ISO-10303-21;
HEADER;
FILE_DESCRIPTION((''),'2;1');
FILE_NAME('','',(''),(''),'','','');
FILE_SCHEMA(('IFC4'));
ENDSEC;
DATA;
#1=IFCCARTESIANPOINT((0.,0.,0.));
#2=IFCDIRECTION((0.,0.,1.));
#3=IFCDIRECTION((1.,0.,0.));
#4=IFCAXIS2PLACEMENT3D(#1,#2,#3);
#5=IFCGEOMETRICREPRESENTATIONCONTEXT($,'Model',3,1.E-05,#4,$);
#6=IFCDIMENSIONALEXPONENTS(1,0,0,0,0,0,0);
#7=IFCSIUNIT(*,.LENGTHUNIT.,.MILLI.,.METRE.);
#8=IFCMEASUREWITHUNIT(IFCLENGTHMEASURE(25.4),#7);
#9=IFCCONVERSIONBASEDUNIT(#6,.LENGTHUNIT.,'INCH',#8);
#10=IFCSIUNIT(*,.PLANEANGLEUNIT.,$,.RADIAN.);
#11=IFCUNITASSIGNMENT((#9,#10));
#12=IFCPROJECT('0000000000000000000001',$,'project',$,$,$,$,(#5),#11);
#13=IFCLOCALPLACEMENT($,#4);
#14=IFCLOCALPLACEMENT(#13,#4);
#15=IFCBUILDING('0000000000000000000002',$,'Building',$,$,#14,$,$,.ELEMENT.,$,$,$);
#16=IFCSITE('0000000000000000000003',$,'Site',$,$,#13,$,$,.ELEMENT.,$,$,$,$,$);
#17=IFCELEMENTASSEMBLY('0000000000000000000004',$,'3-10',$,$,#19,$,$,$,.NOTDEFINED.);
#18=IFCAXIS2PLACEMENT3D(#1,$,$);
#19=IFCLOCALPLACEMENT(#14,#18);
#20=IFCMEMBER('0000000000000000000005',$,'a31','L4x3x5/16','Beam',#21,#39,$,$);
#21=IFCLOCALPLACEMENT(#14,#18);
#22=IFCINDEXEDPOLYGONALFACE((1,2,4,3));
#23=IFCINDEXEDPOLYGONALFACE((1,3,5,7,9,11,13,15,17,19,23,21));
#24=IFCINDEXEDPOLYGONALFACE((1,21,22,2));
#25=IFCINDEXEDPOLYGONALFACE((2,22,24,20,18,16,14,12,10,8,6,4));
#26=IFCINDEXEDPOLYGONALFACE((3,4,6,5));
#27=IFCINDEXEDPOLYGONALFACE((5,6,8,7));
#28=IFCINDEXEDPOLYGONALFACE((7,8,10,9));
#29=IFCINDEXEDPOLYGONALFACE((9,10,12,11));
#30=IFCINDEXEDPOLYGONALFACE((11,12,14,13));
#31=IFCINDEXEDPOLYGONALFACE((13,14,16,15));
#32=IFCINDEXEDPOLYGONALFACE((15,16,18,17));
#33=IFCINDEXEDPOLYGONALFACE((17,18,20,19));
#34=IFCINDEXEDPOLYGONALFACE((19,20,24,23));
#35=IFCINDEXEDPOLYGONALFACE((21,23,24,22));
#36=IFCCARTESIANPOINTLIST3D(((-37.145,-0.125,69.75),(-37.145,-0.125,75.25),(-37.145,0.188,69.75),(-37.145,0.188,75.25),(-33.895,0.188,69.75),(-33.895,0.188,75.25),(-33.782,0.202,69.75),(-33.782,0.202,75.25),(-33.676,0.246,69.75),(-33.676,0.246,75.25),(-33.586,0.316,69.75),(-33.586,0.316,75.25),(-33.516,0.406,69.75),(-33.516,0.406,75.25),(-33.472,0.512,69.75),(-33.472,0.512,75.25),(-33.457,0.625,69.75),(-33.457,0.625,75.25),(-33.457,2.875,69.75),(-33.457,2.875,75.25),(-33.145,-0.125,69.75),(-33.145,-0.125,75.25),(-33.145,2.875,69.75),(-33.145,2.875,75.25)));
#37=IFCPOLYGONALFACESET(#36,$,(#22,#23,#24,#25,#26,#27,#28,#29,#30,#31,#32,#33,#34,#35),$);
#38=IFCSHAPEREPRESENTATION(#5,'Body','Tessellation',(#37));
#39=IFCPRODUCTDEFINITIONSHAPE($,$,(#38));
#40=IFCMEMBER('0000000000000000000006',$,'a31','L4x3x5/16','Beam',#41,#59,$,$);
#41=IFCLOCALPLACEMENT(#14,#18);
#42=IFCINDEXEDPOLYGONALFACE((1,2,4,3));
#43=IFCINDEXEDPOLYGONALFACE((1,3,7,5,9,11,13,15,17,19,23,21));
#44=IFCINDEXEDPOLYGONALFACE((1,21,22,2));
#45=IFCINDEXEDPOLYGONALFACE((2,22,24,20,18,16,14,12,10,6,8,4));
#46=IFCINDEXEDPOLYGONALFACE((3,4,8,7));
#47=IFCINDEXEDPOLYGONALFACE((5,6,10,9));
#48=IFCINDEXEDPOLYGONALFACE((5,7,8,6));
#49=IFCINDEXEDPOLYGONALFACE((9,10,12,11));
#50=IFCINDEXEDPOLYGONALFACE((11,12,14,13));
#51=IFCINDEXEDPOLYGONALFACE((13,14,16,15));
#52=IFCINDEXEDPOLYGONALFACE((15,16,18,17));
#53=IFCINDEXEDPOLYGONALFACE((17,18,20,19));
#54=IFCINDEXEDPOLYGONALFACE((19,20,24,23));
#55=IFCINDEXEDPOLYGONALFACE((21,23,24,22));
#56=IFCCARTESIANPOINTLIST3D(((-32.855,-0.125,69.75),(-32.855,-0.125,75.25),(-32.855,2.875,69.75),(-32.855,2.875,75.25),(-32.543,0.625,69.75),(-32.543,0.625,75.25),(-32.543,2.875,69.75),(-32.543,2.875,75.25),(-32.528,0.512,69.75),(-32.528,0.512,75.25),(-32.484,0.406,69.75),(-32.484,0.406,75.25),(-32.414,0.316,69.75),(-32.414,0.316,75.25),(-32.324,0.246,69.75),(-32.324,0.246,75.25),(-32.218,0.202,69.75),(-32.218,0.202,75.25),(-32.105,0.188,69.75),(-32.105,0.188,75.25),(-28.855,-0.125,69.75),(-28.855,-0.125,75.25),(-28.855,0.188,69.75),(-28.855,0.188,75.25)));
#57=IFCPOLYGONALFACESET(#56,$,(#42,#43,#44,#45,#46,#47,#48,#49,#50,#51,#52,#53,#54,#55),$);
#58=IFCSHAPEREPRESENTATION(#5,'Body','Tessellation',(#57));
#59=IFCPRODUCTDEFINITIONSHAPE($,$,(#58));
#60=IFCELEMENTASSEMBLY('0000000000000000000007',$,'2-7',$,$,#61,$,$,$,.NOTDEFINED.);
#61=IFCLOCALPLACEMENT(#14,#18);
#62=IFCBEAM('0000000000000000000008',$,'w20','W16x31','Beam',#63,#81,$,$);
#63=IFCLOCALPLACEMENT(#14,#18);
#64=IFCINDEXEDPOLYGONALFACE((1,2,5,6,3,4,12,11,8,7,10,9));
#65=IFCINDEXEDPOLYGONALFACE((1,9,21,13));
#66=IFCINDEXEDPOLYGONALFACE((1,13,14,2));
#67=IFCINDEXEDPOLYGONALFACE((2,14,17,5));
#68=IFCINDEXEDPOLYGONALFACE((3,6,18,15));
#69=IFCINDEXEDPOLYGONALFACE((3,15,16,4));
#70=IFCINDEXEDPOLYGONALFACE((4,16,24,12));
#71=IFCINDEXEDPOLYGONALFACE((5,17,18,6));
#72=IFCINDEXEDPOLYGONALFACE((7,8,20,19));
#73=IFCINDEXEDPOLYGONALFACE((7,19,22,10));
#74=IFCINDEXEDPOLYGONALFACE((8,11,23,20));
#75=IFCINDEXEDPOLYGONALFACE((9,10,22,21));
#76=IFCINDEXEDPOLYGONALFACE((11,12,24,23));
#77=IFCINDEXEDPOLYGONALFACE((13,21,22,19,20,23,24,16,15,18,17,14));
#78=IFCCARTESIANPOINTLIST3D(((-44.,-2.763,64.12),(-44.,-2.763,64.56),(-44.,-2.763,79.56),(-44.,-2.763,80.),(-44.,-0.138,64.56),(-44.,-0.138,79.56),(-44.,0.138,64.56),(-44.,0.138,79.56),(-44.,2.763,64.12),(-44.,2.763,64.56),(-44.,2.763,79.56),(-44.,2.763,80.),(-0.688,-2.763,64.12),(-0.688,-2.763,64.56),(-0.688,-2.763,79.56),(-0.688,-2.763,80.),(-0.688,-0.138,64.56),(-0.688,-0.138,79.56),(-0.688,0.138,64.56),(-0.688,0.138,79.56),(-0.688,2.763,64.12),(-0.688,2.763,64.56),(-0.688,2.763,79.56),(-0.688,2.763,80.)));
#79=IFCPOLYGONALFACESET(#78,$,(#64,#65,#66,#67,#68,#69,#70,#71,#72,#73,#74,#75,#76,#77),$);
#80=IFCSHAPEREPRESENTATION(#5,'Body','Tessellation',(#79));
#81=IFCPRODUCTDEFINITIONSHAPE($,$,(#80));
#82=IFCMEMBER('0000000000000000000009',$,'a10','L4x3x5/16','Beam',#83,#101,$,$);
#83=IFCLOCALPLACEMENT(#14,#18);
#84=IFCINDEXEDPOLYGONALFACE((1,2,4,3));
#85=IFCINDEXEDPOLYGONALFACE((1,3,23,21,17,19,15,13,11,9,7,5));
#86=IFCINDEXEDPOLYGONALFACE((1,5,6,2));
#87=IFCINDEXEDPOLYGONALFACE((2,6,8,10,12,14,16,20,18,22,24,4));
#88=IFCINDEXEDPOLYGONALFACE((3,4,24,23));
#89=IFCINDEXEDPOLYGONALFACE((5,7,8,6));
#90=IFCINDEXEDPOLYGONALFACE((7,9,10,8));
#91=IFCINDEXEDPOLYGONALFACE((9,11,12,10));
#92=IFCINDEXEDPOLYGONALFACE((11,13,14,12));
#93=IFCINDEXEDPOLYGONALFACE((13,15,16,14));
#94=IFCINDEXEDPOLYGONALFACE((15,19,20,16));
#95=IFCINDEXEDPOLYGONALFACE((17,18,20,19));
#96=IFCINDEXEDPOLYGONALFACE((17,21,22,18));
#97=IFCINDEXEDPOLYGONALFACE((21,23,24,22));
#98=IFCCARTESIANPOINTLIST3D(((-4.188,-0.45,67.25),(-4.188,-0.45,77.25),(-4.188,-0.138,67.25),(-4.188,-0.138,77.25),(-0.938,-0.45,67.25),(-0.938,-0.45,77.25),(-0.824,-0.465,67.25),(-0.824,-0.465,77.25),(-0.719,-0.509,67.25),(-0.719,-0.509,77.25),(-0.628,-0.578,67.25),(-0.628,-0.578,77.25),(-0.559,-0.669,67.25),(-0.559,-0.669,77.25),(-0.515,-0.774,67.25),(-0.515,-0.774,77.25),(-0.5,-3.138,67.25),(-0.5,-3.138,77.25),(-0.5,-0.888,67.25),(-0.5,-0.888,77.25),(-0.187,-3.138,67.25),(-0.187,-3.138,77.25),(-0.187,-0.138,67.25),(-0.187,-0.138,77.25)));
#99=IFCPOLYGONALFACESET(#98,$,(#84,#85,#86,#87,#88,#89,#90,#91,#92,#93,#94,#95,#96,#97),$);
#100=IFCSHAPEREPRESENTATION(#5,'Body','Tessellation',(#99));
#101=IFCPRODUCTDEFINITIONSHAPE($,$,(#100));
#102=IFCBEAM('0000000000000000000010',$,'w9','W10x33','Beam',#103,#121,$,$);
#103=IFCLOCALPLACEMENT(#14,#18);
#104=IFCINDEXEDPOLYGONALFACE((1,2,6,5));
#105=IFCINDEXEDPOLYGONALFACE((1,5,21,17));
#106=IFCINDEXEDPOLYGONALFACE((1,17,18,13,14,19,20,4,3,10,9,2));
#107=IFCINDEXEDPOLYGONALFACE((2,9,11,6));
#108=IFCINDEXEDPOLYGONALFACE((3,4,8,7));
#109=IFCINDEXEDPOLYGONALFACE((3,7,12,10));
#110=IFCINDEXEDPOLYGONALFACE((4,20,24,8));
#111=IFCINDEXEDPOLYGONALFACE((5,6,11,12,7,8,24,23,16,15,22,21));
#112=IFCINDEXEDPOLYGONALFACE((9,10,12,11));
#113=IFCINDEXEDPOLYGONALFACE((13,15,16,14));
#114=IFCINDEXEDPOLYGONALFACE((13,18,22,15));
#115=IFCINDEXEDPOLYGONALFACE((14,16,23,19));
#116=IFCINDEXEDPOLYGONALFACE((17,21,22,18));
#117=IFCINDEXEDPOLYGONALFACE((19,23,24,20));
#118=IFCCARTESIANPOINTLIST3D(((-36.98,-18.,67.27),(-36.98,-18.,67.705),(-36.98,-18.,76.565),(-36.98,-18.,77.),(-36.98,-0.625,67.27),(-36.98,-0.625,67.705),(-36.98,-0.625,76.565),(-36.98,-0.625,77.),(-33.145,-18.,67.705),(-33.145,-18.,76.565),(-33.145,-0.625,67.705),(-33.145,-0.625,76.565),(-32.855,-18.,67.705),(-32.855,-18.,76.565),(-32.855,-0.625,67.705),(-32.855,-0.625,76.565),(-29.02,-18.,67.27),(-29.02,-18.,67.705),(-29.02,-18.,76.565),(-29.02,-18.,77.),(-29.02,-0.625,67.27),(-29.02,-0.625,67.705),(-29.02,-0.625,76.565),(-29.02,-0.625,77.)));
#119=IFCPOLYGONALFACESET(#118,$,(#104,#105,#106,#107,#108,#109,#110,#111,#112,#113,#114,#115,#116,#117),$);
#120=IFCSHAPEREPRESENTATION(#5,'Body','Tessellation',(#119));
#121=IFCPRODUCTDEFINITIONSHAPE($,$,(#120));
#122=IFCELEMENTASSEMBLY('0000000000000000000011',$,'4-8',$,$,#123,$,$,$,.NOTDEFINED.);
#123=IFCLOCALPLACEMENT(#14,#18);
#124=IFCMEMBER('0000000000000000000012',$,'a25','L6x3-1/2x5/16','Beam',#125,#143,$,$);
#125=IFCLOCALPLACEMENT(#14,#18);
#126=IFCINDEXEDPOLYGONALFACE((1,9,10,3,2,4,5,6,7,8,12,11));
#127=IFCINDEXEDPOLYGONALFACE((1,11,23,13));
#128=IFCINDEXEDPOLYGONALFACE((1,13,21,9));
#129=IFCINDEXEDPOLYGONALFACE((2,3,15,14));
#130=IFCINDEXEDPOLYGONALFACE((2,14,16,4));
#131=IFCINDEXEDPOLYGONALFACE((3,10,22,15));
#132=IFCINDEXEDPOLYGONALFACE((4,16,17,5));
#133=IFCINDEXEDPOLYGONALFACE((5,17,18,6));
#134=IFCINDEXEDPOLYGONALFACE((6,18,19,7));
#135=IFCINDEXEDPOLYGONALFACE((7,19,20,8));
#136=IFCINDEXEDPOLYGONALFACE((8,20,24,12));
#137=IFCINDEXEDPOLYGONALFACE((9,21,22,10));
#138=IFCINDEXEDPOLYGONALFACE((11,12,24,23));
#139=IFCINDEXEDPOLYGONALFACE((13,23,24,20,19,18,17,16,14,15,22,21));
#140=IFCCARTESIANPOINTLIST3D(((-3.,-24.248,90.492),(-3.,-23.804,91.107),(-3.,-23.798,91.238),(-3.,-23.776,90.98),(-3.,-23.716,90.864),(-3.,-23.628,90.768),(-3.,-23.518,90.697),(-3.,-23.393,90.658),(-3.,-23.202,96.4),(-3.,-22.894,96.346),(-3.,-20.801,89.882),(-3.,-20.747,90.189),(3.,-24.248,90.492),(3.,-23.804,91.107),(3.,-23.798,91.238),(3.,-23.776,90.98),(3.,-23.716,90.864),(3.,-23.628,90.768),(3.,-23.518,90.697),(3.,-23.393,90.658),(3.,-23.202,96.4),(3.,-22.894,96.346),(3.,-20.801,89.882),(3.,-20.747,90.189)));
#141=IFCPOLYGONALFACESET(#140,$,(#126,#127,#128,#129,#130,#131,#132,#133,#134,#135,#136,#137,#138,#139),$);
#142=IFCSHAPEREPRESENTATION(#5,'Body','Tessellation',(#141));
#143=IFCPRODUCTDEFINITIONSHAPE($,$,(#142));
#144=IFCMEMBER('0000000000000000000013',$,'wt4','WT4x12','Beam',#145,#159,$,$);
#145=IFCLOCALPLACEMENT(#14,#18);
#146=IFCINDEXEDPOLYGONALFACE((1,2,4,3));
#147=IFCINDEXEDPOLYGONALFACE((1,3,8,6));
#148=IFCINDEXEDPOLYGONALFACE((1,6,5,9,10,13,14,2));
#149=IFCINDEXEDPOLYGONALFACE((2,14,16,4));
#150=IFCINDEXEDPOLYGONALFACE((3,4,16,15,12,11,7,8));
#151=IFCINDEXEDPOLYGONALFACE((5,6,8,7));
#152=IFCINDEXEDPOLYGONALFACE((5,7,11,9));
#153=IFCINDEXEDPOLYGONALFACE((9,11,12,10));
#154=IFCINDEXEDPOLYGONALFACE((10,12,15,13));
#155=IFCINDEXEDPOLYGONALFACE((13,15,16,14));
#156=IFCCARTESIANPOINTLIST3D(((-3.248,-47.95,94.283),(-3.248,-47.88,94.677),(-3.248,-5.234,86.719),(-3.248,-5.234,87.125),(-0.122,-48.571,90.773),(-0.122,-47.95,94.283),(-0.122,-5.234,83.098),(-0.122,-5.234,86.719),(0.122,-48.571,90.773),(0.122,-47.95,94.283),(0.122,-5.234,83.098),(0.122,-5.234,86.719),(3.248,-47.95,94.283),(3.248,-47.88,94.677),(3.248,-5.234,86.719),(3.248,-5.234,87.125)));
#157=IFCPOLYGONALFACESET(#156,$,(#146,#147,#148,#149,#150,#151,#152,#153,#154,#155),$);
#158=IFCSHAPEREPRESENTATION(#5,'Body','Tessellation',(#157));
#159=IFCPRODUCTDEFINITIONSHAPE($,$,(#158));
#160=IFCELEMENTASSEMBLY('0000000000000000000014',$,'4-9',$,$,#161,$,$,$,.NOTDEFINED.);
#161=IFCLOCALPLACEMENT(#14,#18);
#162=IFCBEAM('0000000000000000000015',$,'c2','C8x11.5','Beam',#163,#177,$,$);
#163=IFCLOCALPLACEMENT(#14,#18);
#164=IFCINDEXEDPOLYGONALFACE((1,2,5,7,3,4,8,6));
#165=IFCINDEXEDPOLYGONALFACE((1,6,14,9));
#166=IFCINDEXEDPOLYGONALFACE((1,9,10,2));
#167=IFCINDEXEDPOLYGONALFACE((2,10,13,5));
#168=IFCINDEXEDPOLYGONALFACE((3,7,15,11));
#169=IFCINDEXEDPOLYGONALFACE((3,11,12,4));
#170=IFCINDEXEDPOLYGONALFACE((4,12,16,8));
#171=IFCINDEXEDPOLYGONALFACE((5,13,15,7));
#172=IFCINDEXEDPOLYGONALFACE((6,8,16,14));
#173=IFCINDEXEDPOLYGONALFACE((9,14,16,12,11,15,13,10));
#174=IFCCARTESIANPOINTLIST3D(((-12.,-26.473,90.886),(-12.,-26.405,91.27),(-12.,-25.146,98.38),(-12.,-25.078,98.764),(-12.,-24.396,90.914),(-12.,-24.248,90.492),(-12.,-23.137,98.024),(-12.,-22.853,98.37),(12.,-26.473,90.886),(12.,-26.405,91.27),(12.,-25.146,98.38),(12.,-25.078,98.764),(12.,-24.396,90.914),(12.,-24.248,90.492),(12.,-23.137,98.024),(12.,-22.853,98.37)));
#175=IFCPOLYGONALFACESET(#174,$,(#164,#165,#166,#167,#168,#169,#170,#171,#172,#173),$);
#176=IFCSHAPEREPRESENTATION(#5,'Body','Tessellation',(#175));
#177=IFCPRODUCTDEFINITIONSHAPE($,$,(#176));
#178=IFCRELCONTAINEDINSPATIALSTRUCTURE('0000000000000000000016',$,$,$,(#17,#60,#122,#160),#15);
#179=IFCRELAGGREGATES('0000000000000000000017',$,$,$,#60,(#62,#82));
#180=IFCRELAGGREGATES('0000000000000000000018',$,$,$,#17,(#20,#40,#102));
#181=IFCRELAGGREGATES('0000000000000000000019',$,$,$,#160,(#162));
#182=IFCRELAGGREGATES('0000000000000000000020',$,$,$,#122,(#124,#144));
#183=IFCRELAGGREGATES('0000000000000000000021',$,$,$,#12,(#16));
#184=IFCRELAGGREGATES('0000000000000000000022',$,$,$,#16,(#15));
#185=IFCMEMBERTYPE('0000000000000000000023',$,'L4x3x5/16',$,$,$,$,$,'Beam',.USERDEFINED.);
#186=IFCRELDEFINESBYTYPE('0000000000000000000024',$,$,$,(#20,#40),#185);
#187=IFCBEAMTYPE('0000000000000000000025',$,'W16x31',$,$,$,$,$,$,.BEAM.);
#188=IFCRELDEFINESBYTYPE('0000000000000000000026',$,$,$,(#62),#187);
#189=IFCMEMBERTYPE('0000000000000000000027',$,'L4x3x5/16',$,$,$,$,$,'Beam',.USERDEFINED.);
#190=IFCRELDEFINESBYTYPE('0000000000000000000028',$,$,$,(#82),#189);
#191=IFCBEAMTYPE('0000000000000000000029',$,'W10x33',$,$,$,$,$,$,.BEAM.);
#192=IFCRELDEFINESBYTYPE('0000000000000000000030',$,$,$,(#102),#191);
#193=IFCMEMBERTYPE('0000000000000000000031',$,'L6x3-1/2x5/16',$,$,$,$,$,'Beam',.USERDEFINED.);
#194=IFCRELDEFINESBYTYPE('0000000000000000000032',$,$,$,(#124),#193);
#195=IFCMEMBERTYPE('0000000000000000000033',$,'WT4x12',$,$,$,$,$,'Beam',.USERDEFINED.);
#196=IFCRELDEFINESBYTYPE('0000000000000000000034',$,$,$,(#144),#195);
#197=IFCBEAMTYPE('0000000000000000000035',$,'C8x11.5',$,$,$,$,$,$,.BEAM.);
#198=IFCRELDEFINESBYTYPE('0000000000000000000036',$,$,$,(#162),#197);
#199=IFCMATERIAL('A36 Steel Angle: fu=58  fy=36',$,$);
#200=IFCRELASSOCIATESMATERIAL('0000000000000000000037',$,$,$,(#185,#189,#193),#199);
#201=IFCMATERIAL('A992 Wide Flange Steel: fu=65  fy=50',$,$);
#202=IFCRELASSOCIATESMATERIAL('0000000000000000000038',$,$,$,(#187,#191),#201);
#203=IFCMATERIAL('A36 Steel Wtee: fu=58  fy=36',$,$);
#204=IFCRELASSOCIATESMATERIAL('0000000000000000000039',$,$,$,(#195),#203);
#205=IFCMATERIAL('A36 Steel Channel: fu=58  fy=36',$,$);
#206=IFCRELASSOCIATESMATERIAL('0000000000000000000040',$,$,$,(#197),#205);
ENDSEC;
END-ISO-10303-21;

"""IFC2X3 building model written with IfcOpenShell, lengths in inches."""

from ifc_helpers import new_model, entity, si_unit, converted_unit, frame, frame_2d, origin_with_axes, place, context, project, spatial, i_section, l_section, t_section, u_section, transform_2d, derived_profile, extrude, clip, halfspace, source, transform, mapped, material, type_object, type_shapes, element, aggregate, save


model = new_model("IFC2X3")

# Units and contexts
model_context = context("Model", 3, precision=1e-05, world=origin_with_axes())
ifc_project = project(units=[converted_unit("LENGTHUNIT", "INCH", entity("IfcLengthMeasure", 25.4), si_unit("LENGTHUNIT", "METRE", prefix="MILLI"), dimensions=[1, 0, 0, 0, 0, 0, 0]), si_unit("PLANEANGLEUNIT", "RADIAN")], contexts=[model_context])

# Site, building
site_placement = place(None, origin_with_axes())
site = spatial("IfcSite", under=ifc_project, at=site_placement, Name="Site", CompositionType="ELEMENT")
building_placement = place(site_placement, origin_with_axes())
building = spatial("IfcBuilding", under=site, at=building_placement, Name="Building", CompositionType="ELEMENT")

# Element assembly, members
assembly_1_placement = place(building_placement, frame((-33.0, 0.0, 77.0), z_axis=(0.0, 0.0, 1.0), x_axis=(0.0, -1.0, 0.0)))
assembly_1 = element("IfcElementAssembly", 1, at=assembly_1_placement, inside=building, Name="3-10", PredefinedType="NOTDEFINED")
ifc_material_1 = material(Name="A36 Steel Angle: fu=58  fy=36")
member_type_1 = type_object("IfcMemberType", Name="L4x3x5/16", ElementType="Beam", PredefinedType="USERDEFINED", material=ifc_material_1)
shared_shape_1 = source(origin_with_axes(), model_context, "Body", "SweptSolid", [
    extrude(derived_profile(l_section(Depth=4.0, Width=3.0, Thickness=0.312, FilletRadius=0.438, at=frame_2d((1.5, 2.0), x_axis=(1.0, 0.0))), transform_2d((0.0, 0.0), x_axis=(-1.0, 0.0), y_axis=(0.0, 1.0))), frame((0.0, 0.0, 0.0), z_axis=(1.0, 0.0, 0.0), x_axis=(0.0, 1.0, 0.0)), (0.0, 0.0, 1.0), 5.5),
])
type_shapes(member_type_1, [shared_shape_1])
member_1_placement = place(assembly_1_placement, frame((0.125, -0.145, -7.25), z_axis=(0.0, -1.0, 0.0), x_axis=(0.0, 0.0, 1.0)))
member_1 = element("IfcMember", 2, at=member_1_placement, type_object=member_type_1, Name="a31", Description="L4x3x5/16", ObjectType="Beam", context=model_context, shape_type="MappedRepresentation", body=[
    mapped(shared_shape_1, transform((0.0, 0.0, 0.0), scale=1.0)),
])
member_2_placement = place(assembly_1_placement, frame((0.125, 0.145, -1.75), z_axis=(0.0, 1.0, 0.0), x_axis=(0.0, 0.0, -1.0)))
member_2 = element("IfcMember", 3, at=member_2_placement, type_object=member_type_1, Name="a31", Description="L4x3x5/16", ObjectType="Beam", context=model_context, shape_type="MappedRepresentation", body=[
    mapped(shared_shape_1, transform((0.0, 0.0, 0.0), scale=1.0)),
])

# Element assembly, beam, member
assembly_2_placement = place(building_placement, frame((0.0, 0.0, 80.0), z_axis=(0.0, 0.0, 1.0), x_axis=(-1.0, 0.0, 0.0)))
assembly_2 = element("IfcElementAssembly", 4, at=assembly_2_placement, inside=building, Name="2-7", PredefinedType="NOTDEFINED")
ifc_material_2 = material(Name="A992 Wide Flange Steel: fu=65  fy=50")
beam_type_1 = type_object("IfcBeamType", Name="W16x31", PredefinedType="BEAM", material=ifc_material_2)
shared_shape_2 = source(origin_with_axes(), model_context, "Body", "SweptSolid", [
    extrude(i_section(OverallWidth=5.525, OverallDepth=15.88, WebThickness=0.275, FlangeThickness=0.44, at=frame_2d((0.0, -7.94), x_axis=(1.0, 0.0))), frame((0.0, 0.0, 0.0), z_axis=(1.0, 0.0, 0.0), x_axis=(0.0, 1.0, 0.0)), (0.0, 0.0, 1.0), 43.312),
])
type_shapes(beam_type_1, [shared_shape_2])
beam_1_placement = place(assembly_2_placement, frame((0.688, 0.0, 0.0), z_axis=(0.0, 0.0, 1.0), x_axis=(1.0, 0.0, 0.0)))
beam_1 = element("IfcBeam", 5, at=beam_1_placement, type_object=beam_type_1, Name="w20", Description="W16x31", ObjectType="Beam", context=model_context, shape_type="MappedRepresentation", body=[
    mapped(shared_shape_2, transform((0.0, 0.0, 0.0), scale=1.0)),
])
member_type_2 = type_object("IfcMemberType", Name="L4x3x5/16", ElementType="Beam", PredefinedType="USERDEFINED", material=ifc_material_1)
shared_shape_3 = source(origin_with_axes(), model_context, "Body", "SweptSolid", [
    extrude(l_section(Depth=4.0, Width=3.0, Thickness=0.312, FilletRadius=0.438, at=frame_2d((1.5, 2.0), x_axis=(1.0, 0.0))), frame((0.0, 0.0, 0.0), z_axis=(1.0, 0.0, 0.0), x_axis=(0.0, 1.0, 0.0)), (0.0, 0.0, 1.0), 10.0),
])
type_shapes(member_type_2, [shared_shape_3])
member_3_placement = place(assembly_2_placement, frame((0.188, 0.138, -2.75), z_axis=(1.0, 0.0, 0.0), x_axis=(0.0, 0.0, -1.0)))
member_3 = element("IfcMember", 6, at=member_3_placement, type_object=member_type_2, Name="a10", Description="L4x3x5/16", ObjectType="Beam", context=model_context, shape_type="MappedRepresentation", body=[
    mapped(shared_shape_3, transform((0.0, 0.0, 0.0), scale=1.0)),
])
aggregate(assembly_2, [beam_1, member_3])

# Beam
beam_type_2 = type_object("IfcBeamType", Name="W10x33", PredefinedType="BEAM", material=ifc_material_2)
shared_shape_4 = source(origin_with_axes(), model_context, "Body", "SweptSolid", [
    extrude(i_section(OverallWidth=7.96, OverallDepth=9.73, WebThickness=0.29, FlangeThickness=0.435, at=frame_2d((0.0, -4.865), x_axis=(1.0, 0.0))), frame((0.0, 0.0, 0.0), z_axis=(1.0, 0.0, 0.0), x_axis=(0.0, 1.0, 0.0)), (0.0, 0.0, 1.0), 17.375),
])
type_shapes(beam_type_2, [shared_shape_4])
beam_2_placement = place(assembly_1_placement, frame((0.625, 0.0, 0.0), z_axis=(0.0, 0.0, 1.0), x_axis=(1.0, 0.0, 0.0)))
beam_2 = element("IfcBeam", 7, at=beam_2_placement, type_object=beam_type_2, Name="w9", Description="W10x33", ObjectType="Beam", context=model_context, shape_type="MappedRepresentation", body=[
    mapped(shared_shape_4, transform((0.0, 0.0, 0.0), scale=1.0)),
])
aggregate(assembly_1, [member_1, member_2, beam_2])

# Element assembly, members
assembly_3_placement = place(building_placement, frame((0.0, -48.0, 94.0), z_axis=(0.0, 0.17437, 0.98468), x_axis=(0.0, 0.98468, -0.17437)))
assembly_3 = element("IfcElementAssembly", 8, at=assembly_3_placement, inside=building, Name="4-8", PredefinedType="NOTDEFINED")
member_type_3 = type_object("IfcMemberType", Name="L6x3-1/2x5/16", ElementType="Beam", PredefinedType="USERDEFINED", material=ifc_material_1)
shared_shape_5 = source(origin_with_axes(), model_context, "Body", "SweptSolid", [
    extrude(derived_profile(l_section(Depth=6.0, Width=3.5, Thickness=0.312, FilletRadius=0.5, at=frame_2d((1.75, 3.0), x_axis=(1.0, 0.0))), transform_2d((0.0, 0.0), x_axis=(-1.0, 0.0), y_axis=(0.0, 1.0))), frame((0.0, 0.0, 0.0), z_axis=(1.0, 0.0, 0.0), x_axis=(0.0, 1.0, 0.0)), (0.0, 0.0, 1.0), 6.0),
])
type_shapes(member_type_3, [shared_shape_5])
member_4_placement = place(assembly_3_placement, frame((24.0, 3.0, 0.688), z_axis=(0.0, 0.0, 1.0), x_axis=(0.0, -1.0, 0.0)))
member_4 = element("IfcMember", 9, at=member_4_placement, type_object=member_type_3, Name="a25", Description="L6x3-1/2x5/16", ObjectType="Beam", context=model_context, shape_type="MappedRepresentation", body=[
    mapped(shared_shape_5, transform((0.0, 0.0, 0.0), scale=1.0)),
])
ifc_material_3 = material(Name="A36 Steel Wtee: fu=58  fy=36")
member_type_4 = type_object("IfcMemberType", Name="WT4x12", ElementType="Beam", PredefinedType="USERDEFINED", material=ifc_material_3)
shared_shape_6 = source(origin_with_axes(), model_context, "Body", "Clipping", [
    clip(extrude(t_section(Depth=3.965, FlangeWidth=6.495, WebThickness=0.245, FlangeThickness=0.4, at=frame_2d((0.0, -1.982), x_axis=(1.0, 0.0))), frame((0.0, 0.0, 0.0), z_axis=(1.0, 0.0, 0.0), x_axis=(0.0, 1.0, 0.0)), (0.0, 0.0, 1.0), 44.011), halfspace(frame((44.011, 0.0, -3.965), z_axis=(0.98469, 0.0, 0.17434), x_axis=(-0.17434, 0.0, 0.98469)), False)),
])
type_shapes(member_type_4, [shared_shape_6])
member_5_placement = place(assembly_3_placement, frame((0.0, 0.0, 0.688), z_axis=(0.0, 0.0, 1.0), x_axis=(1.0, 0.0, 0.0)))
member_5 = element("IfcMember", 10, at=member_5_placement, type_object=member_type_4, Name="wt4", Description="WT4x12", ObjectType="Beam", context=model_context, shape_type="MappedRepresentation", body=[
    mapped(shared_shape_6, transform((0.0, 0.0, 0.0), scale=1.0)),
])

# Element assembly, beam
assembly_4_placement = place(building_placement, frame((-12.0, -24.248, 90.492), z_axis=(0.0, -0.17437, -0.98468), x_axis=(1.0, 0.0, 0.0)))
assembly_4 = element("IfcElementAssembly", 11, at=assembly_4_placement, inside=building, Name="4-9", PredefinedType="NOTDEFINED")
ifc_material_4 = material(Name="A36 Steel Channel: fu=58  fy=36")
beam_type_3 = type_object("IfcBeamType", Name="C8x11.5", PredefinedType="BEAM", material=ifc_material_4)
shared_shape_7 = source(origin_with_axes(), model_context, "Body", "SweptSolid", [
    extrude(derived_profile(u_section(Depth=8.0, FlangeWidth=2.26, WebThickness=0.22, FlangeThickness=0.39, at=frame_2d((1.13, -4.0), x_axis=(1.0, 0.0))), transform_2d((0.0, 0.0), x_axis=(-1.0, 0.0), y_axis=(0.0, 1.0))), frame((0.0, 0.0, 0.0), z_axis=(1.0, 0.0, 0.0), x_axis=(0.0, 1.0, 0.0)), (0.0, 0.0, 1.0), 24.0),
])
type_shapes(beam_type_3, [shared_shape_7])
beam_3_placement = place(assembly_4_placement, origin_with_axes())
beam_3 = element("IfcBeam", 12, at=beam_3_placement, type_object=beam_type_3, Name="c2", Description="C8x11.5", ObjectType="Beam", context=model_context, shape_type="MappedRepresentation", body=[
    mapped(shared_shape_7, transform((0.0, 0.0, 0.0), scale=1.0)),
])
aggregate(assembly_4, [beam_3])

aggregate(assembly_3, [member_4, member_5])

save(model, "model.ifc")
